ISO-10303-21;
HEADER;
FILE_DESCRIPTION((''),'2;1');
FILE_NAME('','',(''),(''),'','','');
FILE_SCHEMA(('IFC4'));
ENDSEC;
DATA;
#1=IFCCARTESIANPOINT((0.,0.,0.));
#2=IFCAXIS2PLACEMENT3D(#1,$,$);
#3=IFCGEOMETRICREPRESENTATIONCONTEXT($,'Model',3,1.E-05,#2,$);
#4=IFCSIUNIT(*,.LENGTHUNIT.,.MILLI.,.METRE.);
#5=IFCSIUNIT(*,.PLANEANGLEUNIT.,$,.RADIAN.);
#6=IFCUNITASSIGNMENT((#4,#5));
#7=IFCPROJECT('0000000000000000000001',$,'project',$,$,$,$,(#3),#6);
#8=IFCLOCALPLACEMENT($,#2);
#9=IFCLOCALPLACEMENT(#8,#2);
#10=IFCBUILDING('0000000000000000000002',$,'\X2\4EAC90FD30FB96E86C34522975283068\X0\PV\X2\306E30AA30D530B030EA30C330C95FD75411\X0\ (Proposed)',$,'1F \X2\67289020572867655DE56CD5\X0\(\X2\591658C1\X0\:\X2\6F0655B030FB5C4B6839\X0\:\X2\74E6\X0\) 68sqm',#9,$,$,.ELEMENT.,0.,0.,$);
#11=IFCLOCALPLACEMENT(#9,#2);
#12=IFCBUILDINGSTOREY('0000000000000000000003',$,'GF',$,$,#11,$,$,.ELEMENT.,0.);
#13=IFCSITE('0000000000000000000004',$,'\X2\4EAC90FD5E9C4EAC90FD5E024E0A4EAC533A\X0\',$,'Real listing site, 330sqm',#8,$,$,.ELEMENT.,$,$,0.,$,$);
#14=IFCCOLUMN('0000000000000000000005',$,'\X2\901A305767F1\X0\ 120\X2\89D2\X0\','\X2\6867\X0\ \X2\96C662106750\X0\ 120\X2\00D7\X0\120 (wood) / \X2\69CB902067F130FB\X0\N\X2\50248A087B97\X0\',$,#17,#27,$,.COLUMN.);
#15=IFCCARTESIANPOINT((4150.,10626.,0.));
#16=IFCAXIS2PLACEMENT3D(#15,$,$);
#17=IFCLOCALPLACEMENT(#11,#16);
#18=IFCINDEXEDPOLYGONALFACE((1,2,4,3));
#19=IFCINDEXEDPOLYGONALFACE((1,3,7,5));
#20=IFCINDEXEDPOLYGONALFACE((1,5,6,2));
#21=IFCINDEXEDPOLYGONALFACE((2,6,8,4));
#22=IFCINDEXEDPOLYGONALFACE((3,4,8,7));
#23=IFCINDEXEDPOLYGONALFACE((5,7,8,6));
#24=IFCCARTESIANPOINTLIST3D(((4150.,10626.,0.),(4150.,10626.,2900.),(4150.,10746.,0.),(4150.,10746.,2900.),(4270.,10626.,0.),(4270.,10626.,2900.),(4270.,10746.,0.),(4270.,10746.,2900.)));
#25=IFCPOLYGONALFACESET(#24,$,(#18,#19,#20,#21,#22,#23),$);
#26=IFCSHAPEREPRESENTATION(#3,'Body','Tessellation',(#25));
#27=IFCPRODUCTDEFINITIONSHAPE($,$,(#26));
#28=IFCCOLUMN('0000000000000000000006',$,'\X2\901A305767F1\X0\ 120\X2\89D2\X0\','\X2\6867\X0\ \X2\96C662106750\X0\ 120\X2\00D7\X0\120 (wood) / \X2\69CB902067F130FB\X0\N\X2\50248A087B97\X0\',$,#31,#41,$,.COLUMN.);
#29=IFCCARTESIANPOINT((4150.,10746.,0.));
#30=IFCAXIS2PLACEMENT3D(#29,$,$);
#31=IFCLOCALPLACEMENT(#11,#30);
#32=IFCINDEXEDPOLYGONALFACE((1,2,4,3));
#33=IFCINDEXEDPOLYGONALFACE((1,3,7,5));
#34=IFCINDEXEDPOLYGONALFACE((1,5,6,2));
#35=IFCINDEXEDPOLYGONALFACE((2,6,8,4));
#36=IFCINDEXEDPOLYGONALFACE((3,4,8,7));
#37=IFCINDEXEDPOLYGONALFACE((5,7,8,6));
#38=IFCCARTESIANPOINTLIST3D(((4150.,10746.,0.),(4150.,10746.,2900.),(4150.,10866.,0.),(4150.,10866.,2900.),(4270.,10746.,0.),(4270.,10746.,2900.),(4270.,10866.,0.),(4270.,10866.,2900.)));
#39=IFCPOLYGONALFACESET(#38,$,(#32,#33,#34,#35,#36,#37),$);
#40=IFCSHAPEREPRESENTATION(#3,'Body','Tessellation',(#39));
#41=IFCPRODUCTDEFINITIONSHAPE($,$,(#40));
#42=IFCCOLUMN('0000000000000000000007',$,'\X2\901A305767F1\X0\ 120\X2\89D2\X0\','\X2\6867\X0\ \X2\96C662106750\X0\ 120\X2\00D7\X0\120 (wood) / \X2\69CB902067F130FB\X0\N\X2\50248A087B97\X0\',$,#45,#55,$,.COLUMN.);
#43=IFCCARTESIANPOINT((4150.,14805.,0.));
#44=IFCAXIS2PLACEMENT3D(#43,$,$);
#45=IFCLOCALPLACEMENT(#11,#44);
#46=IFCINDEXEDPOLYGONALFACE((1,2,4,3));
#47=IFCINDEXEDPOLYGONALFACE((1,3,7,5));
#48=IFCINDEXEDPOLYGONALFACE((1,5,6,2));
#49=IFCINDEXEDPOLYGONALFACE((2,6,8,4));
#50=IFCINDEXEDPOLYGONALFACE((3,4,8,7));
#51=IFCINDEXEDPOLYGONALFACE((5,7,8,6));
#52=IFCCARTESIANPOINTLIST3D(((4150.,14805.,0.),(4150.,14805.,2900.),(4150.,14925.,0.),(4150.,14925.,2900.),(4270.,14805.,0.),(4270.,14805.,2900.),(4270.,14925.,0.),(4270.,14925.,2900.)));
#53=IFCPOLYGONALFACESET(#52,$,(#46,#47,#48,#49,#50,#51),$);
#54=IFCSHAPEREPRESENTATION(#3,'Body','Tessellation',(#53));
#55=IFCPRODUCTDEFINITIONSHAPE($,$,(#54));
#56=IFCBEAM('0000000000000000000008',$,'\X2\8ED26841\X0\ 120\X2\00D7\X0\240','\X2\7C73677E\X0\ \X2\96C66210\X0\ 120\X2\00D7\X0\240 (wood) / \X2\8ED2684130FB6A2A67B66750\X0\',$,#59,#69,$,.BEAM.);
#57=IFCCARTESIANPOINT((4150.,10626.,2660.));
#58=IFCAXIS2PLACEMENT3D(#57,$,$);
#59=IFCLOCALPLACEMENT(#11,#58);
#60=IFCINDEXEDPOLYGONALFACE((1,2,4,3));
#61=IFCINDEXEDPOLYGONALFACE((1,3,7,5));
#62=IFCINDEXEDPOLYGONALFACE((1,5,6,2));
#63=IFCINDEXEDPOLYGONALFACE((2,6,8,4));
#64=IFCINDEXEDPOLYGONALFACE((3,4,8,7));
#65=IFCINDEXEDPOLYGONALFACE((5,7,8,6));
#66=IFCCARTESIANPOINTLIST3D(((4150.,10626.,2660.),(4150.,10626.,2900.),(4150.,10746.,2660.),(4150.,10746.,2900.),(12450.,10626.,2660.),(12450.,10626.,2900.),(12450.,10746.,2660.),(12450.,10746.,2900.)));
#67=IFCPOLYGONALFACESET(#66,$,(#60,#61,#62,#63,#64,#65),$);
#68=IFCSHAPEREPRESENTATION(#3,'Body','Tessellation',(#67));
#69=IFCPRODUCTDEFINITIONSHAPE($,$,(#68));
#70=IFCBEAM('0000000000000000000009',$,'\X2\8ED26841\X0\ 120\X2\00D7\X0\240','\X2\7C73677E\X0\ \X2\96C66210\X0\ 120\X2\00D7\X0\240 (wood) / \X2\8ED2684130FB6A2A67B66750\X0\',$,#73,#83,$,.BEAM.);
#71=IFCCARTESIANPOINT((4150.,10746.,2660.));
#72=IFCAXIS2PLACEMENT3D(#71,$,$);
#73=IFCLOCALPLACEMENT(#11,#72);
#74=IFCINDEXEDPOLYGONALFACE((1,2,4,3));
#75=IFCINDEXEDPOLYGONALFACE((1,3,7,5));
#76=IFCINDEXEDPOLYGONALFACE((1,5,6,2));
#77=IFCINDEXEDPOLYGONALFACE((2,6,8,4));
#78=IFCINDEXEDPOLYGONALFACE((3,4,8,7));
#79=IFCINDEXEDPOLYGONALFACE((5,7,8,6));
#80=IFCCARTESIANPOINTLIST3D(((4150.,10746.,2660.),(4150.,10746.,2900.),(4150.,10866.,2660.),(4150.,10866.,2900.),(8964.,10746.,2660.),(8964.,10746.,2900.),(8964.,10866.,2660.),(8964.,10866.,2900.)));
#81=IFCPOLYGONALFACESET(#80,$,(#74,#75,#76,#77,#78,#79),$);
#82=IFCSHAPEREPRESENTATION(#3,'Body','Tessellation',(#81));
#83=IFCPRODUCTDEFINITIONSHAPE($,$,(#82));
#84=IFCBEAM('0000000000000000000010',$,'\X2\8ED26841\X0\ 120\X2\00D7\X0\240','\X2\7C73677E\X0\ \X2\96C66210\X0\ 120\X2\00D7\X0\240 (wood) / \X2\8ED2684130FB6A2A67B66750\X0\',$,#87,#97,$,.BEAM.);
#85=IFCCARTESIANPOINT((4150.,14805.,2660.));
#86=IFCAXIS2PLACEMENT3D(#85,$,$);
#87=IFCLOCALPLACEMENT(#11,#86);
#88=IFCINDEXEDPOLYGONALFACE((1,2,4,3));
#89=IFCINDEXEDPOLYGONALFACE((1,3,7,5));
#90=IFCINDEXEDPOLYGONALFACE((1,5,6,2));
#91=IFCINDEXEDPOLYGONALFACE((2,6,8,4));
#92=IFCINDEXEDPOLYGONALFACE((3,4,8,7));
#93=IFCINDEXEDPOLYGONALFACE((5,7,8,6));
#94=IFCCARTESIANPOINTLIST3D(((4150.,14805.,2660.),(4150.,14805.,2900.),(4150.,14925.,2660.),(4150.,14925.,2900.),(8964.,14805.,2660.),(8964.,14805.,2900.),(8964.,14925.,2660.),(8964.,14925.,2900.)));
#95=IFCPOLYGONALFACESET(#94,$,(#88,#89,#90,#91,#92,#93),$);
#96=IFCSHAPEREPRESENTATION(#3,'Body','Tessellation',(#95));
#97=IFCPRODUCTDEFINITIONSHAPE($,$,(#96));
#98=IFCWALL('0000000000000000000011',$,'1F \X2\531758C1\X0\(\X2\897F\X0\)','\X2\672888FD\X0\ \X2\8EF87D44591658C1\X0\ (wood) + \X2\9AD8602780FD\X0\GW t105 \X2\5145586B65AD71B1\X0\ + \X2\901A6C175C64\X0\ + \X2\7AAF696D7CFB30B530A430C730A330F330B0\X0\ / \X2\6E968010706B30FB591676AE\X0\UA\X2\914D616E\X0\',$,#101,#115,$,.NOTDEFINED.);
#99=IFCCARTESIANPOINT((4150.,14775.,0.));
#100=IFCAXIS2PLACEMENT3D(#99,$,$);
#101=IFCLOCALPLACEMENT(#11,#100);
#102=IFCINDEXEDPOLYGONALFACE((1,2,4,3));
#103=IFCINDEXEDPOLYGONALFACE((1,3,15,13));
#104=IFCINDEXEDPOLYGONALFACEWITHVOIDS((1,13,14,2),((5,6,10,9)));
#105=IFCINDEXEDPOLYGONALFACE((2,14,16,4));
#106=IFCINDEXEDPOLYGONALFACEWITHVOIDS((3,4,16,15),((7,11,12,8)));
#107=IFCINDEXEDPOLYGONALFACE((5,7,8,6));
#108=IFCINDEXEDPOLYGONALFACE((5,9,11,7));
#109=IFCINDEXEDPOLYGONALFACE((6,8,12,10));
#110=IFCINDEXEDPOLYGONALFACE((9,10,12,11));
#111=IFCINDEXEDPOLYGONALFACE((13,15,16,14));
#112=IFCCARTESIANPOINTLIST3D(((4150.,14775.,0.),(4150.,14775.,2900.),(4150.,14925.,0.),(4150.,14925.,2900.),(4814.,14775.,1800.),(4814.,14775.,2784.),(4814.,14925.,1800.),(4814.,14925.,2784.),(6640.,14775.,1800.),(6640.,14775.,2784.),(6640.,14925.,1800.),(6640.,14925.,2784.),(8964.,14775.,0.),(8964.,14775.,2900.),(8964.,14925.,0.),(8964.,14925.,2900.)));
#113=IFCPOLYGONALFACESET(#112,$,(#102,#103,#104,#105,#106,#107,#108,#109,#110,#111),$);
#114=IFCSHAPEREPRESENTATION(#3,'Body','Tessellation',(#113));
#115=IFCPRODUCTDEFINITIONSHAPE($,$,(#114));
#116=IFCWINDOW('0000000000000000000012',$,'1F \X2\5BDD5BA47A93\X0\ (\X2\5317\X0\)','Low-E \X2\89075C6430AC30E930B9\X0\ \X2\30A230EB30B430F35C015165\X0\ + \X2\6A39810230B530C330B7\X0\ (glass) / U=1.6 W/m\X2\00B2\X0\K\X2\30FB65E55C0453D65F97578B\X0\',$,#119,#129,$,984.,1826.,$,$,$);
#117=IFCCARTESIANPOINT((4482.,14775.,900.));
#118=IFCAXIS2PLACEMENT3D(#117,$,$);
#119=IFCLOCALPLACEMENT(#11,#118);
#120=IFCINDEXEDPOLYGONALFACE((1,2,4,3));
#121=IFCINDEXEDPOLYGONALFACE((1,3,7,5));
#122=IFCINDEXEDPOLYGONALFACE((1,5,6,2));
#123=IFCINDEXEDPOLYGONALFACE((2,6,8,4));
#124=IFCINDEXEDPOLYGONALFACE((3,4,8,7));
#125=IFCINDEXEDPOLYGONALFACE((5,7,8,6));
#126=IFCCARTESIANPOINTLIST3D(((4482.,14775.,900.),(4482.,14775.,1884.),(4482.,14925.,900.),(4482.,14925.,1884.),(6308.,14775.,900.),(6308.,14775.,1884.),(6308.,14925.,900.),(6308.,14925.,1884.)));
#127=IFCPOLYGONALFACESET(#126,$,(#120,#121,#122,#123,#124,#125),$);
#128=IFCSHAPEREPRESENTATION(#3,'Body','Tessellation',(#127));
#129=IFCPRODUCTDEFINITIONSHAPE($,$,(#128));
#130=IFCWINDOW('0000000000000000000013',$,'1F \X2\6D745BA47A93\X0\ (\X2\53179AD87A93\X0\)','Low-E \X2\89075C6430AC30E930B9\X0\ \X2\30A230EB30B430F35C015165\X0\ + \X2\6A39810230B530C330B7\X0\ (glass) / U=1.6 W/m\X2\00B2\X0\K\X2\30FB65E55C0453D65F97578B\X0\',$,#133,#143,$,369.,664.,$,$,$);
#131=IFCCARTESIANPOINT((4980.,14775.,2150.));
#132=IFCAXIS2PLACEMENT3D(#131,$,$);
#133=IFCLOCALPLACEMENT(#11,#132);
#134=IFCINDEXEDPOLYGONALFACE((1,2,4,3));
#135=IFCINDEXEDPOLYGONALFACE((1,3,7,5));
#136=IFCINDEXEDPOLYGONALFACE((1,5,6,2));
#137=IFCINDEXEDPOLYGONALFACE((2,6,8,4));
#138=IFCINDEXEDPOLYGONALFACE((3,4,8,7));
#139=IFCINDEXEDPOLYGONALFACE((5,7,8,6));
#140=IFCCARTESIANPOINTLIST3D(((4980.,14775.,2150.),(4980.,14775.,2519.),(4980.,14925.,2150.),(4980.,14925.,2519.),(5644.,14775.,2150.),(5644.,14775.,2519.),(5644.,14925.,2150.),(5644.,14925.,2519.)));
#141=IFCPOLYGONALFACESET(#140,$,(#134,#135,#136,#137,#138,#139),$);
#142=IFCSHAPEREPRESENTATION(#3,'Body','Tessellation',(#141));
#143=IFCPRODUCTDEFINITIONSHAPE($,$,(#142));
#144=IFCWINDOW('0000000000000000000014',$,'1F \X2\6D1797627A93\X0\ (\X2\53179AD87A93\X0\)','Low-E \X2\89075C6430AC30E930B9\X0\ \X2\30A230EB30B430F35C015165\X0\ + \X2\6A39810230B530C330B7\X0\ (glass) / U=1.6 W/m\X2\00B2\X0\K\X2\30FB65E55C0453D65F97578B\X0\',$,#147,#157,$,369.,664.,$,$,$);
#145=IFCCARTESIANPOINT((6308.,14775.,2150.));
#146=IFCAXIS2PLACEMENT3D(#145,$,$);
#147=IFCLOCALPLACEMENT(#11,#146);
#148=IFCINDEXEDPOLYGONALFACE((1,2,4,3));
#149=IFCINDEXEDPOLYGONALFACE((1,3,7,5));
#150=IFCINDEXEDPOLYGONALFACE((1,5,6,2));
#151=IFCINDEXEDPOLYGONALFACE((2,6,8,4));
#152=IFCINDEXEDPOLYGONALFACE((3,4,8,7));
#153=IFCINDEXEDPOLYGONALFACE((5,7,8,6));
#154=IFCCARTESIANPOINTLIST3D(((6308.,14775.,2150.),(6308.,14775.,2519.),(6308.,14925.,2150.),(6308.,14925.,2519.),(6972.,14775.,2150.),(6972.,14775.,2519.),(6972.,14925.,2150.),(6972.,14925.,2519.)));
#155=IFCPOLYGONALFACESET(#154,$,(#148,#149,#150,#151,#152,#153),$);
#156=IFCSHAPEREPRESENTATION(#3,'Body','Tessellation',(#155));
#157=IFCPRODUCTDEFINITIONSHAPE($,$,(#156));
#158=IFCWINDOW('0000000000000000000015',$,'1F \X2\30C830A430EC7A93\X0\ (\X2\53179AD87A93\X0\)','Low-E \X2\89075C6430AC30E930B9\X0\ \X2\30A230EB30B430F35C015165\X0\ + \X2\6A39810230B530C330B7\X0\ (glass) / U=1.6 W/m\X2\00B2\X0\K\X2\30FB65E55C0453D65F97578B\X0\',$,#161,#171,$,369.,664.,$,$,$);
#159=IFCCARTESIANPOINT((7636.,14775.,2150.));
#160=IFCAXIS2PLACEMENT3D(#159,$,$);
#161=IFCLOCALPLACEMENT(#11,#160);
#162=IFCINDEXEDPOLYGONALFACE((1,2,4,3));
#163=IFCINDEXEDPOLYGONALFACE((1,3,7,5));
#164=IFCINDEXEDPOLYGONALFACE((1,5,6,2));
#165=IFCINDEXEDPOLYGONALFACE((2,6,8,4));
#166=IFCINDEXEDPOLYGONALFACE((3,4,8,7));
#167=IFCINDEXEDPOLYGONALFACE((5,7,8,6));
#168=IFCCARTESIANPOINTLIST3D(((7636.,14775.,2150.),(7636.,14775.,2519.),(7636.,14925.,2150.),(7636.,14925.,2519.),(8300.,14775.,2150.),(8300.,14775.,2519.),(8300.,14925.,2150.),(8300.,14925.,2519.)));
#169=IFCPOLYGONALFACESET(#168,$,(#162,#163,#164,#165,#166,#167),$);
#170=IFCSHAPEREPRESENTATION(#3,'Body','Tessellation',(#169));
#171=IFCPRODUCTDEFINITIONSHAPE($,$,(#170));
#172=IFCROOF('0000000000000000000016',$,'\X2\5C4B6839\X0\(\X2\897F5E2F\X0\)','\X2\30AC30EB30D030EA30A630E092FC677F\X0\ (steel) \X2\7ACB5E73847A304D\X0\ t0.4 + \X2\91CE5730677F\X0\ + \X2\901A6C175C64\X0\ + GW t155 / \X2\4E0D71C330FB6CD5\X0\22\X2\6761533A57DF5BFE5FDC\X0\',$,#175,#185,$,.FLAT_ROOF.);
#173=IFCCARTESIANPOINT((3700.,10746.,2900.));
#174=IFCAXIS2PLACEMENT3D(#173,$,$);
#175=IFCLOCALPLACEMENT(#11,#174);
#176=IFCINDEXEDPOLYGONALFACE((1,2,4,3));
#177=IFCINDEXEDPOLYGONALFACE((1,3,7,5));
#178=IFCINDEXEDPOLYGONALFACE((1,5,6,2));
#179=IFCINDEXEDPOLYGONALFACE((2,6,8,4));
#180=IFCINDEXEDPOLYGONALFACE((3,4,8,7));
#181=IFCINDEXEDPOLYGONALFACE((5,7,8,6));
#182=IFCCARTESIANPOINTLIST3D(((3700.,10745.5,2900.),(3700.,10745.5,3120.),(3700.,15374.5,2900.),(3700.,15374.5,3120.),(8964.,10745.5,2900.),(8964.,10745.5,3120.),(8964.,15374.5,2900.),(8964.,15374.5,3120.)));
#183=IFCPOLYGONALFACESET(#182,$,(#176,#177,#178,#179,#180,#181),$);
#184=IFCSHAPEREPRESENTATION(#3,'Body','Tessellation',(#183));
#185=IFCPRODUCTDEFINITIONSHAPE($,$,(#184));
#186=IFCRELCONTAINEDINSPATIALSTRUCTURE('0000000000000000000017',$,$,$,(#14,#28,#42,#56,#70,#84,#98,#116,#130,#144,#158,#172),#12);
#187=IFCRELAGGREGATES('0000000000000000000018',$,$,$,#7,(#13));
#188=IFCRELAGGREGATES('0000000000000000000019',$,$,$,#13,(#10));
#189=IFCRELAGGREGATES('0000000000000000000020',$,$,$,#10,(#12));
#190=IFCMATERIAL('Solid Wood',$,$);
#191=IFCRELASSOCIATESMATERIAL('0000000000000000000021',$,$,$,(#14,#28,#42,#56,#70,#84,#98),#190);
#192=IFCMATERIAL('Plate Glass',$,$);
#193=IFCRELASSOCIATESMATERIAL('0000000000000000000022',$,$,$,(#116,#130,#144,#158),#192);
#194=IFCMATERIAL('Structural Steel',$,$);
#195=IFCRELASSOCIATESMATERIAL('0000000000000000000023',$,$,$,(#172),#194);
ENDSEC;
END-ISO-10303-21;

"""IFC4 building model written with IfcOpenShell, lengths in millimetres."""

from ifc_helpers import new_model, si_unit, frame, frame_2d, origin, place, context, project, spatial, rectangle, extrude, material, element, fill, save


model = new_model("IFC4")

# Units and contexts
model_context = context("Model", 3, precision=1e-05, world=origin())
ifc_project = project(units=[si_unit("LENGTHUNIT", "METRE", prefix="MILLI"), si_unit("PLANEANGLEUNIT", "RADIAN")], contexts=[model_context])

# Site, building, storey
site_placement = place(None, origin())
site = spatial("IfcSite", under=ifc_project, at=site_placement, Name="京都府京都市上京区", ObjectType="Real listing site, 330sqm", CompositionType="ELEMENT", RefElevation=0.0)
building_placement = place(site_placement, origin())
building = spatial("IfcBuilding", under=site, at=building_placement, Name="京都・雨水利用とPVのオフグリッド志向 (Proposed)", ObjectType="1F 木造在来工法(外壁:漆喰・屋根:瓦) 68sqm", CompositionType="ELEMENT", ElevationOfRefHeight=0.0, ElevationOfTerrain=0.0)
storey_placement = place(building_placement, origin())
storey = spatial("IfcBuildingStorey", under=building, at=storey_placement, Name="GF", CompositionType="ELEMENT", Elevation=0.0)

# Columns
ifc_material_1 = material(Name="Solid Wood")
column_1_placement = place(storey_placement, frame((4150.0, 10626.0, 0.0)))
element("IfcColumn", 1, at=column_1_placement, inside=storey, material=ifc_material_1, Name="通し柱 120角", Description="桧 集成材 120×120 (wood) / 構造柱・N値計算", PredefinedType="COLUMN", context=model_context, shape_type="SweptSolid", body=[
    extrude(rectangle(XDim=120.0, YDim=120.0, at=frame_2d((60.0, 60.0))), frame((4150.0, 10626.0, 0.0)), (0.0, 0.0, 1.0), 2900.0),
])
column_2_placement = place(storey_placement, frame((4150.0, 10746.0, 0.0)))
element("IfcColumn", 2, at=column_2_placement, inside=storey, material=ifc_material_1, Name="通し柱 120角", Description="桧 集成材 120×120 (wood) / 構造柱・N値計算", PredefinedType="COLUMN", context=model_context, shape_type="SweptSolid", body=[
    extrude(rectangle(XDim=120.0, YDim=120.0, at=frame_2d((60.0, 60.0))), frame((4150.0, 10746.0, 0.0)), (0.0, 0.0, 1.0), 2900.0),
])
column_3_placement = place(storey_placement, frame((4150.0, 14805.0, 0.0)))
element("IfcColumn", 3, at=column_3_placement, inside=storey, material=ifc_material_1, Name="通し柱 120角", Description="桧 集成材 120×120 (wood) / 構造柱・N値計算", PredefinedType="COLUMN", context=model_context, shape_type="SweptSolid", body=[
    extrude(rectangle(XDim=120.0, YDim=120.0, at=frame_2d((60.0, 60.0))), frame((4150.0, 14805.0, 0.0)), (0.0, 0.0, 1.0), 2900.0),
])

# Beams
beam_1_placement = place(storey_placement, frame((4150.0, 10626.0, 2660.0)))
element("IfcBeam", 4, at=beam_1_placement, inside=storey, material=ifc_material_1, Name="軒桁 120×240", Description="米松 集成 120×240 (wood) / 軒桁・横架材", PredefinedType="BEAM", context=model_context, shape_type="SweptSolid", body=[
    extrude(rectangle(XDim=8300.0, YDim=120.0, at=frame_2d((4150.0, 60.0))), frame((4150.0, 10626.0, 2660.0)), (0.0, 0.0, 1.0), 240.0),
])
beam_2_placement = place(storey_placement, frame((4150.0, 10746.0, 2660.0)))
element("IfcBeam", 5, at=beam_2_placement, inside=storey, material=ifc_material_1, Name="軒桁 120×240", Description="米松 集成 120×240 (wood) / 軒桁・横架材", PredefinedType="BEAM", context=model_context, shape_type="SweptSolid", body=[
    extrude(rectangle(XDim=4814.0, YDim=120.0, at=frame_2d((2407.0, 60.0))), frame((4150.0, 10746.0, 2660.0)), (0.0, 0.0, 1.0), 240.0),
])
beam_3_placement = place(storey_placement, frame((4150.0, 14805.0, 2660.0)))
element("IfcBeam", 6, at=beam_3_placement, inside=storey, material=ifc_material_1, Name="軒桁 120×240", Description="米松 集成 120×240 (wood) / 軒桁・横架材", PredefinedType="BEAM", context=model_context, shape_type="SweptSolid", body=[
    extrude(rectangle(XDim=4814.0, YDim=120.0, at=frame_2d((2407.0, 60.0))), frame((4150.0, 14805.0, 2660.0)), (0.0, 0.0, 1.0), 240.0),
])

# Wall, openings, windows
wall_1_placement = place(storey_placement, frame((4150.0, 14775.0, 0.0)))
wall_1 = element("IfcWall", 7, at=wall_1_placement, inside=storey, material=ifc_material_1, Name="1F 北壁(西)", Description="木製 軸組外壁 (wood) + 高性能GW t105 充填断熱 + 通気層 + 窯業系サイディング / 準耐火・外皮UA配慮", PredefinedType="NOTDEFINED", context=model_context, shape_type="SweptSolid", body=[
    extrude(rectangle(XDim=4814.0, YDim=150.0, at=frame_2d((2407.0, 75.0))), frame((4150.0, 14775.0, 0.0)), (0.0, 0.0, 1.0), 2900.0),
])
opening_1_placement = place(storey_placement, frame((4482.0, 14775.0, 900.0)))
opening_1 = element("IfcOpeningElement", 8, at=opening_1_placement, cuts=wall_1, PredefinedType="NOTDEFINED", context=model_context, shape_type="SweptSolid", body=[
    extrude(rectangle(XDim=1826.0, YDim=150.0, at=frame_2d((913.0, 75.0))), frame((4482.0, 14775.0, 900.0)), (0.0, 0.0, 1.0), 984.0),
])
opening_2_placement = place(storey_placement, frame((4980.0, 14775.0, 2150.0)))
opening_2 = element("IfcOpeningElement", 9, at=opening_2_placement, cuts=wall_1, PredefinedType="NOTDEFINED", context=model_context, shape_type="SweptSolid", body=[
    extrude(rectangle(XDim=664.0, YDim=150.0, at=frame_2d((332.0, 75.0))), frame((4980.0, 14775.0, 2150.0)), (0.0, 0.0, 1.0), 369.0),
])
opening_3_placement = place(storey_placement, frame((6308.0, 14775.0, 2150.0)))
opening_3 = element("IfcOpeningElement", 10, at=opening_3_placement, cuts=wall_1, PredefinedType="NOTDEFINED", context=model_context, shape_type="SweptSolid", body=[
    extrude(rectangle(XDim=664.0, YDim=150.0, at=frame_2d((332.0, 75.0))), frame((6308.0, 14775.0, 2150.0)), (0.0, 0.0, 1.0), 369.0),
])
opening_4_placement = place(storey_placement, frame((7636.0, 14775.0, 2150.0)))
opening_4 = element("IfcOpeningElement", 11, at=opening_4_placement, cuts=wall_1, PredefinedType="NOTDEFINED", context=model_context, shape_type="SweptSolid", body=[
    extrude(rectangle(XDim=664.0, YDim=150.0, at=frame_2d((332.0, 75.0))), frame((7636.0, 14775.0, 2150.0)), (0.0, 0.0, 1.0), 369.0),
])
ifc_material_2 = material(Name="Plate Glass")
window_1_placement = place(storey_placement, frame((4482.0, 14775.0, 900.0)))
window_1 = element("IfcWindow", 12, at=window_1_placement, inside=storey, material=ifc_material_2, Name="1F 寝室窓 (北)", Description="Low-E 複層ガラス アルゴン封入 + 樹脂サッシ (glass) / U=1.6 W/m²K・日射取得型", OverallHeight=984.0, OverallWidth=1826.0, context=model_context, shape_type="SweptSolid", body=[
    extrude(rectangle(XDim=1826.0, YDim=150.0, at=frame_2d((913.0, 75.0))), frame((4482.0, 14775.0, 900.0)), (0.0, 0.0, 1.0), 984.0),
])
fill(opening_1, window_1)
window_2_placement = place(storey_placement, frame((4980.0, 14775.0, 2150.0)))
window_2 = element("IfcWindow", 13, at=window_2_placement, inside=storey, material=ifc_material_2, Name="1F 浴室窓 (北高窓)", Description="Low-E 複層ガラス アルゴン封入 + 樹脂サッシ (glass) / U=1.6 W/m²K・日射取得型", OverallHeight=369.0, OverallWidth=664.0, context=model_context, shape_type="SweptSolid", body=[
    extrude(rectangle(XDim=664.0, YDim=150.0, at=frame_2d((332.0, 75.0))), frame((4980.0, 14775.0, 2150.0)), (0.0, 0.0, 1.0), 369.0),
])
fill(opening_2, window_2)
window_3_placement = place(storey_placement, frame((6308.0, 14775.0, 2150.0)))
window_3 = element("IfcWindow", 14, at=window_3_placement, inside=storey, material=ifc_material_2, Name="1F 洗面窓 (北高窓)", Description="Low-E 複層ガラス アルゴン封入 + 樹脂サッシ (glass) / U=1.6 W/m²K・日射取得型", OverallHeight=369.0, OverallWidth=664.0, context=model_context, shape_type="SweptSolid", body=[
    extrude(rectangle(XDim=664.0, YDim=150.0, at=frame_2d((332.0, 75.0))), frame((6308.0, 14775.0, 2150.0)), (0.0, 0.0, 1.0), 369.0),
])
fill(opening_3, window_3)
window_4_placement = place(storey_placement, frame((7636.0, 14775.0, 2150.0)))
window_4 = element("IfcWindow", 15, at=window_4_placement, inside=storey, material=ifc_material_2, Name="1F トイレ窓 (北高窓)", Description="Low-E 複層ガラス アルゴン封入 + 樹脂サッシ (glass) / U=1.6 W/m²K・日射取得型", OverallHeight=369.0, OverallWidth=664.0, context=model_context, shape_type="SweptSolid", body=[
    extrude(rectangle(XDim=664.0, YDim=150.0, at=frame_2d((332.0, 75.0))), frame((7636.0, 14775.0, 2150.0)), (0.0, 0.0, 1.0), 369.0),
])
fill(opening_4, window_4)

# Roof
ifc_material_3 = material(Name="Structural Steel")
roof_placement = place(storey_placement, frame((3700.0, 10746.0, 2900.0)))
element("IfcRoof", 16, at=roof_placement, inside=storey, material=ifc_material_3, Name="屋根(西帯)", Description="ガルバリウム鋼板 (steel) 立平葺き t0.4 + 野地板 + 通気層 + GW t155 / 不燃・法22条区域対応", PredefinedType="FLAT_ROOF", context=model_context, shape_type="SweptSolid", body=[
    extrude(rectangle(XDim=5264.0, YDim=4629.0, at=frame_2d((2632.0, 2314.0))), frame((3700.0, 10746.0, 2900.0)), (0.0, 0.0, 1.0), 220.0),
])

save(model, "model.ifc")
